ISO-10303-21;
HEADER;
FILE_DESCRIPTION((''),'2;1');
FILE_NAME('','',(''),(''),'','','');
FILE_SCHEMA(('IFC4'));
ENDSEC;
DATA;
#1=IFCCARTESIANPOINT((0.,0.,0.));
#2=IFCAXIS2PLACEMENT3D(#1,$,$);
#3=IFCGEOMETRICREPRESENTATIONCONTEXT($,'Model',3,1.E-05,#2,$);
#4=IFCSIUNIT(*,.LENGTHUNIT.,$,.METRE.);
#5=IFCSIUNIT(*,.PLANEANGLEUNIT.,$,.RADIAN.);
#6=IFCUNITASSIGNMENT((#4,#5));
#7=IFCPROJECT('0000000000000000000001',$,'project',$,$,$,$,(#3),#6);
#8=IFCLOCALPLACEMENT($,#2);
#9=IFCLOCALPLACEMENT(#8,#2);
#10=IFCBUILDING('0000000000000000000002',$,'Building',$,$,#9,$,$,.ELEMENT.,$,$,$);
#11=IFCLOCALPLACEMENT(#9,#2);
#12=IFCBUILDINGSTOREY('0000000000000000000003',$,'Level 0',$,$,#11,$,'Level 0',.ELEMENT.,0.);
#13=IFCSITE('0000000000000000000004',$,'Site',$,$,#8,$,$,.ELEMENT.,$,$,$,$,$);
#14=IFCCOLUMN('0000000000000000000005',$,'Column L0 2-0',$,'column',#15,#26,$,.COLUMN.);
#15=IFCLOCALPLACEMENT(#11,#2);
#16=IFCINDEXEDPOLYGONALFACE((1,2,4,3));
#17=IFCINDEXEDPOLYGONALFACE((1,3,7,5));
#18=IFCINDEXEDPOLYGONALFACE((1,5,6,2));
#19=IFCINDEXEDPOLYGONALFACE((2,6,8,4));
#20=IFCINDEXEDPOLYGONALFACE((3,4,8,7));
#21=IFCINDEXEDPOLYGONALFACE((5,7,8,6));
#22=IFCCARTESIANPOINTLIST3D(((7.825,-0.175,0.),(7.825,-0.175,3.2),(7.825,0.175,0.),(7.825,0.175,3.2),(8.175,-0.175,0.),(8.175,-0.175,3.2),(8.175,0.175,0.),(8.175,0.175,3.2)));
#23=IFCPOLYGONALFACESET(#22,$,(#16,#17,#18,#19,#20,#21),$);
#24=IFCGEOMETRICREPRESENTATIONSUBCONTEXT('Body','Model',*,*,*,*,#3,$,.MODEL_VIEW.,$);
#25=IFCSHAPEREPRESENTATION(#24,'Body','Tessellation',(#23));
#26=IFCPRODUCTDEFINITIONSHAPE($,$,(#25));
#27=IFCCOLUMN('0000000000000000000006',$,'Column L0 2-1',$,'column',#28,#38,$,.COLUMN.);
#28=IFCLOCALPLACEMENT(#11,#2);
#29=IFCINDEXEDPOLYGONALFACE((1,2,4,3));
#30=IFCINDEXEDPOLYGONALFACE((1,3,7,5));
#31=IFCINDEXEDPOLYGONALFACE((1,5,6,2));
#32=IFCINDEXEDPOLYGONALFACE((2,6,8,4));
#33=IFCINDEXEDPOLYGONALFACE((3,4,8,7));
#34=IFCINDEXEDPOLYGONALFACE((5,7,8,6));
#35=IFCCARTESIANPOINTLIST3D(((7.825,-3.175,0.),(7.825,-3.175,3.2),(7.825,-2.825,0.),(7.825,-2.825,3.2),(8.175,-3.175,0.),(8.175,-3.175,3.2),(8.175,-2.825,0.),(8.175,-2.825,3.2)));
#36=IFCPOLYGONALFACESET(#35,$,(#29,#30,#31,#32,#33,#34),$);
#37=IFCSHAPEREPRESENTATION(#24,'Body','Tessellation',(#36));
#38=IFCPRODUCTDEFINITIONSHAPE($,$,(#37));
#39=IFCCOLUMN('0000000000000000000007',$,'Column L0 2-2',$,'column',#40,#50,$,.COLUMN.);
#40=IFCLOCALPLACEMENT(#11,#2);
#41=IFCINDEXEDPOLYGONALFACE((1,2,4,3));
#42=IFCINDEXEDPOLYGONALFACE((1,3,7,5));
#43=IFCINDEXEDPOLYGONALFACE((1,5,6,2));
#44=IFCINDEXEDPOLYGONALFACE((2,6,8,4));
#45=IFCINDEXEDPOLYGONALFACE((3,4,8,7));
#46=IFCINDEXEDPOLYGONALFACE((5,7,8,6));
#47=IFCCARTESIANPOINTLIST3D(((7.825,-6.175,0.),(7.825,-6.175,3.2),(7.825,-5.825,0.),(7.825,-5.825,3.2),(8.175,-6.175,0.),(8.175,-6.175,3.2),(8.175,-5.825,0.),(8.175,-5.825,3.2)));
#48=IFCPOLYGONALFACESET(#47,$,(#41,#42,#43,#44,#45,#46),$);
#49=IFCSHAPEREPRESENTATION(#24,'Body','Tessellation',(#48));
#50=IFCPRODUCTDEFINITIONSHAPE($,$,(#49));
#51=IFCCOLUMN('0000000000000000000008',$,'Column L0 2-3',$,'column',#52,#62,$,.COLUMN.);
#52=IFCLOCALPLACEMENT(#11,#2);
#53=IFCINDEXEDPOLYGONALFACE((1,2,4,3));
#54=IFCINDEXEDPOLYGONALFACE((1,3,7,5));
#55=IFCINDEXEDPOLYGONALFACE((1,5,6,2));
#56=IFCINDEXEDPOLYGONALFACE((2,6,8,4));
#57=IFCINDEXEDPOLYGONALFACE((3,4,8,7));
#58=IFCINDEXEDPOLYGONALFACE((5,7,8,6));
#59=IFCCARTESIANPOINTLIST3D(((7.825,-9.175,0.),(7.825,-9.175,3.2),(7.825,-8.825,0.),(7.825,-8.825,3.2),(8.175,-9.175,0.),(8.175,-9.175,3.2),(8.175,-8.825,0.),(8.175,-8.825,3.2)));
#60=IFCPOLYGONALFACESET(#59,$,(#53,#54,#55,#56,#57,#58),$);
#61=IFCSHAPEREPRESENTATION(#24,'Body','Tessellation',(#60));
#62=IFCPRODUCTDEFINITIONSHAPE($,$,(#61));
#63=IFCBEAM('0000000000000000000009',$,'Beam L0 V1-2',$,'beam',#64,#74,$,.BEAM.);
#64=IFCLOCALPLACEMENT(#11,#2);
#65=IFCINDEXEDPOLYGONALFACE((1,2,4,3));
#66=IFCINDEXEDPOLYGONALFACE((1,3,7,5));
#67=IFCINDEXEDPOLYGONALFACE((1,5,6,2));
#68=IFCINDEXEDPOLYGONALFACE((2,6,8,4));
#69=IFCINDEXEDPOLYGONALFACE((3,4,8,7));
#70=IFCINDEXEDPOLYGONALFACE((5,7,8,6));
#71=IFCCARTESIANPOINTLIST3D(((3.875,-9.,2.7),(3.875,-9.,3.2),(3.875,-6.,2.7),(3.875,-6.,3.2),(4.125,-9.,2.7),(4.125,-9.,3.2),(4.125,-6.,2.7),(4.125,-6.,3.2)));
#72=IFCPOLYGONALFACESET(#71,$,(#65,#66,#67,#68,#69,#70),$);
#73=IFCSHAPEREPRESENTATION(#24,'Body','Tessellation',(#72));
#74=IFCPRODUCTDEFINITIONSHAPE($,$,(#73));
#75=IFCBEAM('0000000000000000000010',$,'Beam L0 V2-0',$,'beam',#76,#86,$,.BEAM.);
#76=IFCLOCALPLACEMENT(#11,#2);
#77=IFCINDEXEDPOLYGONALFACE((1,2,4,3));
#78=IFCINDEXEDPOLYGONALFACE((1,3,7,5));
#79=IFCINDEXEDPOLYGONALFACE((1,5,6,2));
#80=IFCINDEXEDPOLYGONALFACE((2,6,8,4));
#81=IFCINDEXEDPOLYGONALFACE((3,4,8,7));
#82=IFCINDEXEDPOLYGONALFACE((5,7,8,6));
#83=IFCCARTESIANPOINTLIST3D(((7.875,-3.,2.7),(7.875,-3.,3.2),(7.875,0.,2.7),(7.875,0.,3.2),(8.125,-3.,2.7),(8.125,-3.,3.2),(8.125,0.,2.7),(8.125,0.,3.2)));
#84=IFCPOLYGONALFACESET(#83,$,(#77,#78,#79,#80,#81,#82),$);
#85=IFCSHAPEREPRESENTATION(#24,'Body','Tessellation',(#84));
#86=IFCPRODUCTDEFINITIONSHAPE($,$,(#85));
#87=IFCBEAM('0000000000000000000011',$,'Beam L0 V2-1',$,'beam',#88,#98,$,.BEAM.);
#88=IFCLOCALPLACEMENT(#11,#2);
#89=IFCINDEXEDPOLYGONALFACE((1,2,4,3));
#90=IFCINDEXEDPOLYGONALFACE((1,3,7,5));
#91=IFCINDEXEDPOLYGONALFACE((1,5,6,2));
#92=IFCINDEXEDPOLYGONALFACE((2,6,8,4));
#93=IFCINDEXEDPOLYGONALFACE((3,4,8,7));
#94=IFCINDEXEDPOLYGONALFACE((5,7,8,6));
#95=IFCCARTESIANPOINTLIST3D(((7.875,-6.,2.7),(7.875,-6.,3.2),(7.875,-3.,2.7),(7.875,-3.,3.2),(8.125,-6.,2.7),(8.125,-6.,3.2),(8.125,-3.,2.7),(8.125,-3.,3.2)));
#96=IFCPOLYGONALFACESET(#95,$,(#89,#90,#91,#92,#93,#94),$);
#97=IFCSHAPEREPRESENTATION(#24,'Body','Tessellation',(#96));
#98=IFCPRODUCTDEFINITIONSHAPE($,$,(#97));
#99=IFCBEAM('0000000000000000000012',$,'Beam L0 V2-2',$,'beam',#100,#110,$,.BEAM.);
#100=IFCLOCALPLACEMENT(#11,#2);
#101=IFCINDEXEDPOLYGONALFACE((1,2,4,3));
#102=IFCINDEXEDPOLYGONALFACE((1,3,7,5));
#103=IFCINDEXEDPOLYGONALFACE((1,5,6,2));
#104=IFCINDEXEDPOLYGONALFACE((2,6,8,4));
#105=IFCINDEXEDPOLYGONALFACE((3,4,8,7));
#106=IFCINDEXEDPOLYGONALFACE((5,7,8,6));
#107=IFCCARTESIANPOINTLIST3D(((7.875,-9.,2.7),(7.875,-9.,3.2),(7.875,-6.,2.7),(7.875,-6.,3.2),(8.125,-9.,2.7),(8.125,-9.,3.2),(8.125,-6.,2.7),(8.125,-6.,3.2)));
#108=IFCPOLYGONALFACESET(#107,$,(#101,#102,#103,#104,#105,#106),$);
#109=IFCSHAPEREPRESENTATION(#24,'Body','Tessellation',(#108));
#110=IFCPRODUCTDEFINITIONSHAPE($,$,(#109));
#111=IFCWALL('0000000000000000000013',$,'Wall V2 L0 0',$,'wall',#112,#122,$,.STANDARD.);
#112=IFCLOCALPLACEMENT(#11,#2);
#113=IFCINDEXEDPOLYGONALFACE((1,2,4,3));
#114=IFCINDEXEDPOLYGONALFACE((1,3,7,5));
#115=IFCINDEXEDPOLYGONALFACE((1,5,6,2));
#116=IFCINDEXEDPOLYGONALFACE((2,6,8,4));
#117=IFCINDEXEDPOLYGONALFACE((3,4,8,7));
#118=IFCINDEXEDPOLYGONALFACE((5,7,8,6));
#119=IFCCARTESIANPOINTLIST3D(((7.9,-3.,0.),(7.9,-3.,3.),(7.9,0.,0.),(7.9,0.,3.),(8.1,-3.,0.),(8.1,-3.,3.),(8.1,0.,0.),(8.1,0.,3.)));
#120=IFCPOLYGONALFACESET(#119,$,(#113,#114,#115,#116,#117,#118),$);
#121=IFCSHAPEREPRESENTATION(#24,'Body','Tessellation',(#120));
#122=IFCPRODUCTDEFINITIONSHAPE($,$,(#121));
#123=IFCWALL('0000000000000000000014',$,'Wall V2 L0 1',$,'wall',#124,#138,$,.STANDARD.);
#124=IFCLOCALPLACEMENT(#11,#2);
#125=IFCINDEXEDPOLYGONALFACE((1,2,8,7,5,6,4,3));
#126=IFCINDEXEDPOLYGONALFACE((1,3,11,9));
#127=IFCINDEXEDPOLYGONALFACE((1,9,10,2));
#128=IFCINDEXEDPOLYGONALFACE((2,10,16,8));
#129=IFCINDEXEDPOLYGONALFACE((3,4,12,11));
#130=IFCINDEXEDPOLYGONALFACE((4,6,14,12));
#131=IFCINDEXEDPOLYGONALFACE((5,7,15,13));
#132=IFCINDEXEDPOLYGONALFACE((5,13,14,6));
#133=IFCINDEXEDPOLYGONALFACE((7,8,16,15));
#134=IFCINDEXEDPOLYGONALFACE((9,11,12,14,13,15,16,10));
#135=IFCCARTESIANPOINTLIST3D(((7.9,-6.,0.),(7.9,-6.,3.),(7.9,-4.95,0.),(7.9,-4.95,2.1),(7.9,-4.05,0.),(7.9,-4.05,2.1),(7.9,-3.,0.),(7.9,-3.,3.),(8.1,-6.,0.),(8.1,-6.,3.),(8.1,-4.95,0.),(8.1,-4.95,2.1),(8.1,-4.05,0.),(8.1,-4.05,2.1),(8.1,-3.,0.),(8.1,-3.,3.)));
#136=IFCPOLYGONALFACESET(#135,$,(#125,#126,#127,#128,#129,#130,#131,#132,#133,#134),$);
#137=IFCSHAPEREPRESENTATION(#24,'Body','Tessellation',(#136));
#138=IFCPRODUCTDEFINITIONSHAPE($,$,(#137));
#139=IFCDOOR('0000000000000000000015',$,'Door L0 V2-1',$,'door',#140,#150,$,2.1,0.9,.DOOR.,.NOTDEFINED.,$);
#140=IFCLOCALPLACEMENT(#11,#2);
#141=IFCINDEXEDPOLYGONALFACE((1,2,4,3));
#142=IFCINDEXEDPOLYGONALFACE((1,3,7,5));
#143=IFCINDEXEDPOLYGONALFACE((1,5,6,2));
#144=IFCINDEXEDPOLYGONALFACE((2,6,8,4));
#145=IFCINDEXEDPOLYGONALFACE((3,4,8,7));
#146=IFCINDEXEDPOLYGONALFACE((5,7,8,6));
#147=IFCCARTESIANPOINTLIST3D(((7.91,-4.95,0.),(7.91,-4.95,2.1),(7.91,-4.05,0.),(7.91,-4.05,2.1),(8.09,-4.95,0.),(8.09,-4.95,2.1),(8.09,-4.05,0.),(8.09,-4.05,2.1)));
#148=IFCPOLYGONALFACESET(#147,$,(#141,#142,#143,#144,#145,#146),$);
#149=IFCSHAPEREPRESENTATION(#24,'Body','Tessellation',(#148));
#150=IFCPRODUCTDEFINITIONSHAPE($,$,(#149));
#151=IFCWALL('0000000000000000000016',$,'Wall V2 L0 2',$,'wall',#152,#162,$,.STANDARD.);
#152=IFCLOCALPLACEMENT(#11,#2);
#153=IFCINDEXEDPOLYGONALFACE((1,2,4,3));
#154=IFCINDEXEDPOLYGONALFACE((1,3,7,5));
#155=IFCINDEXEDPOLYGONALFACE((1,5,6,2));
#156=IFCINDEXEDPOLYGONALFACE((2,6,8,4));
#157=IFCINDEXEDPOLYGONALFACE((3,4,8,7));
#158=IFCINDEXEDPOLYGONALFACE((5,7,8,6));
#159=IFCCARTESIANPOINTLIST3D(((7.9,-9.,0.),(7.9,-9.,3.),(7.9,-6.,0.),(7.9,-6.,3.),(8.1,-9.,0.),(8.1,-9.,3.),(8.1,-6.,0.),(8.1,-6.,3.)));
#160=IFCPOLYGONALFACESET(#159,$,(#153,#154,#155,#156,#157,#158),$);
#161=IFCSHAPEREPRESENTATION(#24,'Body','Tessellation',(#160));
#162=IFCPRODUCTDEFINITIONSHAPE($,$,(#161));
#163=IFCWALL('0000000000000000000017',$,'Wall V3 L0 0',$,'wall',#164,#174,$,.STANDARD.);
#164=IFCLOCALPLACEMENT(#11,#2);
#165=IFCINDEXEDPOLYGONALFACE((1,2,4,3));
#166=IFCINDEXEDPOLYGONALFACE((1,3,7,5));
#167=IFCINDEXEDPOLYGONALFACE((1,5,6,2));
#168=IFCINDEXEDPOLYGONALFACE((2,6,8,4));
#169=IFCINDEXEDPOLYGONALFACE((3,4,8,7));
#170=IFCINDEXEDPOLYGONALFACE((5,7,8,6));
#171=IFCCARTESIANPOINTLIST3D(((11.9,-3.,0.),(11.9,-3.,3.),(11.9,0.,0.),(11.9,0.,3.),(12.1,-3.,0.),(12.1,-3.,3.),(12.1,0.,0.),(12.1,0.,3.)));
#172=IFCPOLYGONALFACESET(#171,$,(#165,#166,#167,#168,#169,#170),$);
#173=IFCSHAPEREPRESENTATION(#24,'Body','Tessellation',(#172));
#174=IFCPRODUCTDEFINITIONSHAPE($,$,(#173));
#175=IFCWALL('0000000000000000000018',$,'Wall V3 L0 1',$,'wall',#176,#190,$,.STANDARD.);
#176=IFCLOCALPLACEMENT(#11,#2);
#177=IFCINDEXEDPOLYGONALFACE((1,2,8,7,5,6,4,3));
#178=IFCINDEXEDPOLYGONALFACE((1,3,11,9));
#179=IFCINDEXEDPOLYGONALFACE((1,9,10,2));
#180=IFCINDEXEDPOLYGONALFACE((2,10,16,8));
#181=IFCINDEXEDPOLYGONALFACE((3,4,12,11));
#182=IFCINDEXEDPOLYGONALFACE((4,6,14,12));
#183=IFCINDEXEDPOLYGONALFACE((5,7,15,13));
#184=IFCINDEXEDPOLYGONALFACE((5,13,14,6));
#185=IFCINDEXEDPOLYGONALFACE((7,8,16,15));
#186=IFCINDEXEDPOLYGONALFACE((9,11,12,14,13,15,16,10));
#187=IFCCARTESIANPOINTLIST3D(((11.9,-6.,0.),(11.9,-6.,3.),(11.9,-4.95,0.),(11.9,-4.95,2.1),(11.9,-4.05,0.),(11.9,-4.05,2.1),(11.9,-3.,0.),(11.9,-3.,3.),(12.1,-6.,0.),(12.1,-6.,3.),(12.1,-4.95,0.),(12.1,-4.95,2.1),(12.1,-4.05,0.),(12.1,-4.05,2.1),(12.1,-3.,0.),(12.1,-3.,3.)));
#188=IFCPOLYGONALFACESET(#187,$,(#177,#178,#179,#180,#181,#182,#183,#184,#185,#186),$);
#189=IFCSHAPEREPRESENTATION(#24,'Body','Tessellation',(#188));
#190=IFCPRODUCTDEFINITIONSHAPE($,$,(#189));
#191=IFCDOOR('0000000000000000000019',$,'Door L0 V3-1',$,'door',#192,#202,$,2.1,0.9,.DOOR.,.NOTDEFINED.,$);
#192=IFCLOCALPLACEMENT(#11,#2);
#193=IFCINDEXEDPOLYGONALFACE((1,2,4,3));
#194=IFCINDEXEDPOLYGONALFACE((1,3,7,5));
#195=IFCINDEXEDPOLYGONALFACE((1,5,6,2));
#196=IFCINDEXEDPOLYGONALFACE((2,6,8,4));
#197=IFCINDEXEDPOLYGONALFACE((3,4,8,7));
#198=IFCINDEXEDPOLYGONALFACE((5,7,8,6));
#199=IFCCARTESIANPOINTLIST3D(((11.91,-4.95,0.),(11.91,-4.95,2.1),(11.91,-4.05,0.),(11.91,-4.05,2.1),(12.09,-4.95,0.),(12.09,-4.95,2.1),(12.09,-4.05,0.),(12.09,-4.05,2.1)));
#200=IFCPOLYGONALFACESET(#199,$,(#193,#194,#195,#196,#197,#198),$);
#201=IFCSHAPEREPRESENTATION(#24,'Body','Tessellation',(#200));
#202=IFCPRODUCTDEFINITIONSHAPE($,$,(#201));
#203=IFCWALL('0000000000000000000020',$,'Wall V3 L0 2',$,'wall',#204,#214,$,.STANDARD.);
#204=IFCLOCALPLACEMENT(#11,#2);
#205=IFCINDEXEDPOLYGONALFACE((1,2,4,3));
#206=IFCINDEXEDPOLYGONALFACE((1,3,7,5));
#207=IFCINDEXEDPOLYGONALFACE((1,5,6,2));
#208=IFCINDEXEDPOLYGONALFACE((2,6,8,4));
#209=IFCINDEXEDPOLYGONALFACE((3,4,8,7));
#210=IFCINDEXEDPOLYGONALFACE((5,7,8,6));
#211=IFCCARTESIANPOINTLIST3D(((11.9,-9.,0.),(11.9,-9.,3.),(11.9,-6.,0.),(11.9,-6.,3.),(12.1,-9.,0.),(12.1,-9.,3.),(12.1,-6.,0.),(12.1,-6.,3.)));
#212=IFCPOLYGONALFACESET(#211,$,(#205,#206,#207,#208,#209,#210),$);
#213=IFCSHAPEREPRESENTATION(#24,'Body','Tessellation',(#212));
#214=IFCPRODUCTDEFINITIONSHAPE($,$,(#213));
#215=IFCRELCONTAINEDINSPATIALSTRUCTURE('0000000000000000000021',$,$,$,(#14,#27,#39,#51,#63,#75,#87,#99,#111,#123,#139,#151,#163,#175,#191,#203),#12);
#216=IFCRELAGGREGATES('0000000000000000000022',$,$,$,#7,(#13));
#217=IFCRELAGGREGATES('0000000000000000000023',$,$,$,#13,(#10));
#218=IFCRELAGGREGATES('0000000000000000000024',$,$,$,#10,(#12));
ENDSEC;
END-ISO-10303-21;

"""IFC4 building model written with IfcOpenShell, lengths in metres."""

from ifc_helpers import new_model, si_unit, frame, frame_2d, origin, origin_2d, place, context, subcontext, project, spatial, rectangle, extrude, element, fill, save


model = new_model("IFC4")

# Units and contexts
model_context = context("Model", 3, precision=1e-05, world=origin())
body_context = subcontext(model_context, "Body", "Model", "MODEL_VIEW")
ifc_project = project(units=[si_unit("LENGTHUNIT", "METRE"), si_unit("PLANEANGLEUNIT", "RADIAN")], contexts=[model_context])

# Site, building, storey
site_placement = place(None, origin())
site = spatial("IfcSite", under=ifc_project, at=site_placement, Name="Site", CompositionType="ELEMENT")
building_placement = place(site_placement, origin())
building = spatial("IfcBuilding", under=site, at=building_placement, Name="Building", CompositionType="ELEMENT")
storey_placement = place(building_placement, origin())
storey = spatial("IfcBuildingStorey", under=building, at=storey_placement, Name="Level 0", LongName="Level 0", CompositionType="ELEMENT", Elevation=0.0)

# Columns
for number, where, name in (
    (1, (8.0, 0.0, 0.0), "Column L0 2-0"),
    (2, (8.0, -3.0, 0.0), "Column L0 2-1"),
    (3, (8.0, -6.0, 0.0), "Column L0 2-2"),
    (4, (8.0, -9.0, 0.0), "Column L0 2-3"),
):
    element("IfcColumn", number, at=place(storey_placement, frame(where)), inside=storey, Name=name, ObjectType="column", PredefinedType="COLUMN", context=body_context, shape_type="SweptSolid", body=[
        extrude(rectangle(XDim=0.35, YDim=0.35, at=origin_2d()), origin(), (0.0, 0.0, 1.0), 3.2),
    ])

# Beams
for number, where, z_axis, x_axis, name in (
    (5, (4.0, -6.0, 2.95), (0.0, -1.0, 0.0), (0.0, 0.0, 1.0), "Beam L0 V1-2"),
    (6, (8.0, 0.0, 2.95), (0.0, -1.0, 0.0), (0.0, 0.0, 1.0), "Beam L0 V2-0"),
    (7, (8.0, -3.0, 2.95), (0.0, -1.0, 0.0), (0.0, 0.0, 1.0), "Beam L0 V2-1"),
    (8, (8.0, -6.0, 2.95), (0.0, -1.0, 0.0), (0.0, 0.0, 1.0), "Beam L0 V2-2"),
):
    element("IfcBeam", number, at=place(storey_placement, frame(where, z_axis=z_axis, x_axis=x_axis)), inside=storey, Name=name, ObjectType="beam", PredefinedType="BEAM", context=body_context, shape_type="SweptSolid", body=[
        extrude(rectangle(XDim=0.5, YDim=0.25, at=origin_2d()), origin(), (0.0, 0.0, 1.0), 3.0),
    ])

# Wall
wall_1_placement = place(storey_placement, frame((8.0, 0.0, 0.0), z_axis=(0.0, 0.0, 1.0), x_axis=(0.0, -1.0, 0.0)))
element("IfcWall", 9, at=wall_1_placement, inside=storey, Name="Wall V2 L0 0", ObjectType="wall", PredefinedType="STANDARD", context=body_context, shape_type="SweptSolid", body=[
    extrude(rectangle(XDim=3.0, YDim=0.2, at=frame_2d((1.5, 0.0))), origin(), (0.0, 0.0, 1.0), 3.0),
])

# Wall, opening, door
wall_2_placement = place(storey_placement, frame((8.0, -3.0, 0.0), z_axis=(0.0, 0.0, 1.0), x_axis=(0.0, -1.0, 0.0)))
wall_2 = element("IfcWall", 10, at=wall_2_placement, inside=storey, Name="Wall V2 L0 1", ObjectType="wall", PredefinedType="STANDARD", context=body_context, shape_type="SweptSolid", body=[
    extrude(rectangle(XDim=3.0, YDim=0.2, at=frame_2d((1.5, 0.0))), origin(), (0.0, 0.0, 1.0), 3.0),
])
opening_1_placement = place(storey_placement, frame((8.0, -4.5, 0.0), z_axis=(0.0, 0.0, 1.0), x_axis=(0.0, -1.0, 0.0)))
opening_1 = element("IfcOpeningElement", 11, at=opening_1_placement, cuts=wall_2, ObjectType="Opening", PredefinedType="OPENING", context=body_context, shape_type="SweptSolid", body=[
    extrude(rectangle(XDim=0.9, YDim=0.22, at=origin_2d()), origin(), (0.0, 0.0, 1.0), 2.1),
])
door_1_placement = place(storey_placement, frame((8.0, -4.5, 0.0), z_axis=(0.0, 0.0, 1.0), x_axis=(0.0, -1.0, 0.0)))
door_1 = element("IfcDoor", 12, at=door_1_placement, inside=storey, Name="Door L0 V2-1", ObjectType="door", OperationType="NOTDEFINED", OverallHeight=2.1, OverallWidth=0.9, PredefinedType="DOOR", context=body_context, shape_type="SweptSolid", body=[
    extrude(rectangle(XDim=0.9, YDim=0.18, at=origin_2d()), origin(), (0.0, 0.0, 1.0), 2.1),
])
fill(opening_1, door_1)

# Walls
for number, where, z_axis, x_axis, name in (
    (13, (8.0, -6.0, 0.0), (0.0, 0.0, 1.0), (0.0, -1.0, 0.0), "Wall V2 L0 2"),
    (14, (12.0, 0.0, 0.0), (0.0, 0.0, 1.0), (0.0, -1.0, 0.0), "Wall V3 L0 0"),
):
    element("IfcWall", number, at=place(storey_placement, frame(where, z_axis=z_axis, x_axis=x_axis)), inside=storey, Name=name, ObjectType="wall", PredefinedType="STANDARD", context=body_context, shape_type="SweptSolid", body=[
        extrude(rectangle(XDim=3.0, YDim=0.2, at=frame_2d((1.5, 0.0))), origin(), (0.0, 0.0, 1.0), 3.0),
    ])

# Wall, opening, door
wall_3_placement = place(storey_placement, frame((12.0, -3.0, 0.0), z_axis=(0.0, 0.0, 1.0), x_axis=(0.0, -1.0, 0.0)))
wall_3 = element("IfcWall", 15, at=wall_3_placement, inside=storey, Name="Wall V3 L0 1", ObjectType="wall", PredefinedType="STANDARD", context=body_context, shape_type="SweptSolid", body=[
    extrude(rectangle(XDim=3.0, YDim=0.2, at=frame_2d((1.5, 0.0))), origin(), (0.0, 0.0, 1.0), 3.0),
])
opening_2_placement = place(storey_placement, frame((12.0, -4.5, 0.0), z_axis=(0.0, 0.0, 1.0), x_axis=(0.0, -1.0, 0.0)))
opening_2 = element("IfcOpeningElement", 16, at=opening_2_placement, cuts=wall_3, ObjectType="Opening", PredefinedType="OPENING", context=body_context, shape_type="SweptSolid", body=[
    extrude(rectangle(XDim=0.9, YDim=0.22, at=origin_2d()), origin(), (0.0, 0.0, 1.0), 2.1),
])
door_2_placement = place(storey_placement, frame((12.0, -4.5, 0.0), z_axis=(0.0, 0.0, 1.0), x_axis=(0.0, -1.0, 0.0)))
door_2 = element("IfcDoor", 17, at=door_2_placement, inside=storey, Name="Door L0 V3-1", ObjectType="door", OperationType="NOTDEFINED", OverallHeight=2.1, OverallWidth=0.9, PredefinedType="DOOR", context=body_context, shape_type="SweptSolid", body=[
    extrude(rectangle(XDim=0.9, YDim=0.18, at=origin_2d()), origin(), (0.0, 0.0, 1.0), 2.1),
])
fill(opening_2, door_2)

# Wall
wall_4_placement = place(storey_placement, frame((12.0, -6.0, 0.0), z_axis=(0.0, 0.0, 1.0), x_axis=(0.0, -1.0, 0.0)))
element("IfcWall", 18, at=wall_4_placement, inside=storey, Name="Wall V3 L0 2", ObjectType="wall", PredefinedType="STANDARD", context=body_context, shape_type="SweptSolid", body=[
    extrude(rectangle(XDim=3.0, YDim=0.2, at=frame_2d((1.5, 0.0))), origin(), (0.0, 0.0, 1.0), 3.0),
])

save(model, "model.ifc")
